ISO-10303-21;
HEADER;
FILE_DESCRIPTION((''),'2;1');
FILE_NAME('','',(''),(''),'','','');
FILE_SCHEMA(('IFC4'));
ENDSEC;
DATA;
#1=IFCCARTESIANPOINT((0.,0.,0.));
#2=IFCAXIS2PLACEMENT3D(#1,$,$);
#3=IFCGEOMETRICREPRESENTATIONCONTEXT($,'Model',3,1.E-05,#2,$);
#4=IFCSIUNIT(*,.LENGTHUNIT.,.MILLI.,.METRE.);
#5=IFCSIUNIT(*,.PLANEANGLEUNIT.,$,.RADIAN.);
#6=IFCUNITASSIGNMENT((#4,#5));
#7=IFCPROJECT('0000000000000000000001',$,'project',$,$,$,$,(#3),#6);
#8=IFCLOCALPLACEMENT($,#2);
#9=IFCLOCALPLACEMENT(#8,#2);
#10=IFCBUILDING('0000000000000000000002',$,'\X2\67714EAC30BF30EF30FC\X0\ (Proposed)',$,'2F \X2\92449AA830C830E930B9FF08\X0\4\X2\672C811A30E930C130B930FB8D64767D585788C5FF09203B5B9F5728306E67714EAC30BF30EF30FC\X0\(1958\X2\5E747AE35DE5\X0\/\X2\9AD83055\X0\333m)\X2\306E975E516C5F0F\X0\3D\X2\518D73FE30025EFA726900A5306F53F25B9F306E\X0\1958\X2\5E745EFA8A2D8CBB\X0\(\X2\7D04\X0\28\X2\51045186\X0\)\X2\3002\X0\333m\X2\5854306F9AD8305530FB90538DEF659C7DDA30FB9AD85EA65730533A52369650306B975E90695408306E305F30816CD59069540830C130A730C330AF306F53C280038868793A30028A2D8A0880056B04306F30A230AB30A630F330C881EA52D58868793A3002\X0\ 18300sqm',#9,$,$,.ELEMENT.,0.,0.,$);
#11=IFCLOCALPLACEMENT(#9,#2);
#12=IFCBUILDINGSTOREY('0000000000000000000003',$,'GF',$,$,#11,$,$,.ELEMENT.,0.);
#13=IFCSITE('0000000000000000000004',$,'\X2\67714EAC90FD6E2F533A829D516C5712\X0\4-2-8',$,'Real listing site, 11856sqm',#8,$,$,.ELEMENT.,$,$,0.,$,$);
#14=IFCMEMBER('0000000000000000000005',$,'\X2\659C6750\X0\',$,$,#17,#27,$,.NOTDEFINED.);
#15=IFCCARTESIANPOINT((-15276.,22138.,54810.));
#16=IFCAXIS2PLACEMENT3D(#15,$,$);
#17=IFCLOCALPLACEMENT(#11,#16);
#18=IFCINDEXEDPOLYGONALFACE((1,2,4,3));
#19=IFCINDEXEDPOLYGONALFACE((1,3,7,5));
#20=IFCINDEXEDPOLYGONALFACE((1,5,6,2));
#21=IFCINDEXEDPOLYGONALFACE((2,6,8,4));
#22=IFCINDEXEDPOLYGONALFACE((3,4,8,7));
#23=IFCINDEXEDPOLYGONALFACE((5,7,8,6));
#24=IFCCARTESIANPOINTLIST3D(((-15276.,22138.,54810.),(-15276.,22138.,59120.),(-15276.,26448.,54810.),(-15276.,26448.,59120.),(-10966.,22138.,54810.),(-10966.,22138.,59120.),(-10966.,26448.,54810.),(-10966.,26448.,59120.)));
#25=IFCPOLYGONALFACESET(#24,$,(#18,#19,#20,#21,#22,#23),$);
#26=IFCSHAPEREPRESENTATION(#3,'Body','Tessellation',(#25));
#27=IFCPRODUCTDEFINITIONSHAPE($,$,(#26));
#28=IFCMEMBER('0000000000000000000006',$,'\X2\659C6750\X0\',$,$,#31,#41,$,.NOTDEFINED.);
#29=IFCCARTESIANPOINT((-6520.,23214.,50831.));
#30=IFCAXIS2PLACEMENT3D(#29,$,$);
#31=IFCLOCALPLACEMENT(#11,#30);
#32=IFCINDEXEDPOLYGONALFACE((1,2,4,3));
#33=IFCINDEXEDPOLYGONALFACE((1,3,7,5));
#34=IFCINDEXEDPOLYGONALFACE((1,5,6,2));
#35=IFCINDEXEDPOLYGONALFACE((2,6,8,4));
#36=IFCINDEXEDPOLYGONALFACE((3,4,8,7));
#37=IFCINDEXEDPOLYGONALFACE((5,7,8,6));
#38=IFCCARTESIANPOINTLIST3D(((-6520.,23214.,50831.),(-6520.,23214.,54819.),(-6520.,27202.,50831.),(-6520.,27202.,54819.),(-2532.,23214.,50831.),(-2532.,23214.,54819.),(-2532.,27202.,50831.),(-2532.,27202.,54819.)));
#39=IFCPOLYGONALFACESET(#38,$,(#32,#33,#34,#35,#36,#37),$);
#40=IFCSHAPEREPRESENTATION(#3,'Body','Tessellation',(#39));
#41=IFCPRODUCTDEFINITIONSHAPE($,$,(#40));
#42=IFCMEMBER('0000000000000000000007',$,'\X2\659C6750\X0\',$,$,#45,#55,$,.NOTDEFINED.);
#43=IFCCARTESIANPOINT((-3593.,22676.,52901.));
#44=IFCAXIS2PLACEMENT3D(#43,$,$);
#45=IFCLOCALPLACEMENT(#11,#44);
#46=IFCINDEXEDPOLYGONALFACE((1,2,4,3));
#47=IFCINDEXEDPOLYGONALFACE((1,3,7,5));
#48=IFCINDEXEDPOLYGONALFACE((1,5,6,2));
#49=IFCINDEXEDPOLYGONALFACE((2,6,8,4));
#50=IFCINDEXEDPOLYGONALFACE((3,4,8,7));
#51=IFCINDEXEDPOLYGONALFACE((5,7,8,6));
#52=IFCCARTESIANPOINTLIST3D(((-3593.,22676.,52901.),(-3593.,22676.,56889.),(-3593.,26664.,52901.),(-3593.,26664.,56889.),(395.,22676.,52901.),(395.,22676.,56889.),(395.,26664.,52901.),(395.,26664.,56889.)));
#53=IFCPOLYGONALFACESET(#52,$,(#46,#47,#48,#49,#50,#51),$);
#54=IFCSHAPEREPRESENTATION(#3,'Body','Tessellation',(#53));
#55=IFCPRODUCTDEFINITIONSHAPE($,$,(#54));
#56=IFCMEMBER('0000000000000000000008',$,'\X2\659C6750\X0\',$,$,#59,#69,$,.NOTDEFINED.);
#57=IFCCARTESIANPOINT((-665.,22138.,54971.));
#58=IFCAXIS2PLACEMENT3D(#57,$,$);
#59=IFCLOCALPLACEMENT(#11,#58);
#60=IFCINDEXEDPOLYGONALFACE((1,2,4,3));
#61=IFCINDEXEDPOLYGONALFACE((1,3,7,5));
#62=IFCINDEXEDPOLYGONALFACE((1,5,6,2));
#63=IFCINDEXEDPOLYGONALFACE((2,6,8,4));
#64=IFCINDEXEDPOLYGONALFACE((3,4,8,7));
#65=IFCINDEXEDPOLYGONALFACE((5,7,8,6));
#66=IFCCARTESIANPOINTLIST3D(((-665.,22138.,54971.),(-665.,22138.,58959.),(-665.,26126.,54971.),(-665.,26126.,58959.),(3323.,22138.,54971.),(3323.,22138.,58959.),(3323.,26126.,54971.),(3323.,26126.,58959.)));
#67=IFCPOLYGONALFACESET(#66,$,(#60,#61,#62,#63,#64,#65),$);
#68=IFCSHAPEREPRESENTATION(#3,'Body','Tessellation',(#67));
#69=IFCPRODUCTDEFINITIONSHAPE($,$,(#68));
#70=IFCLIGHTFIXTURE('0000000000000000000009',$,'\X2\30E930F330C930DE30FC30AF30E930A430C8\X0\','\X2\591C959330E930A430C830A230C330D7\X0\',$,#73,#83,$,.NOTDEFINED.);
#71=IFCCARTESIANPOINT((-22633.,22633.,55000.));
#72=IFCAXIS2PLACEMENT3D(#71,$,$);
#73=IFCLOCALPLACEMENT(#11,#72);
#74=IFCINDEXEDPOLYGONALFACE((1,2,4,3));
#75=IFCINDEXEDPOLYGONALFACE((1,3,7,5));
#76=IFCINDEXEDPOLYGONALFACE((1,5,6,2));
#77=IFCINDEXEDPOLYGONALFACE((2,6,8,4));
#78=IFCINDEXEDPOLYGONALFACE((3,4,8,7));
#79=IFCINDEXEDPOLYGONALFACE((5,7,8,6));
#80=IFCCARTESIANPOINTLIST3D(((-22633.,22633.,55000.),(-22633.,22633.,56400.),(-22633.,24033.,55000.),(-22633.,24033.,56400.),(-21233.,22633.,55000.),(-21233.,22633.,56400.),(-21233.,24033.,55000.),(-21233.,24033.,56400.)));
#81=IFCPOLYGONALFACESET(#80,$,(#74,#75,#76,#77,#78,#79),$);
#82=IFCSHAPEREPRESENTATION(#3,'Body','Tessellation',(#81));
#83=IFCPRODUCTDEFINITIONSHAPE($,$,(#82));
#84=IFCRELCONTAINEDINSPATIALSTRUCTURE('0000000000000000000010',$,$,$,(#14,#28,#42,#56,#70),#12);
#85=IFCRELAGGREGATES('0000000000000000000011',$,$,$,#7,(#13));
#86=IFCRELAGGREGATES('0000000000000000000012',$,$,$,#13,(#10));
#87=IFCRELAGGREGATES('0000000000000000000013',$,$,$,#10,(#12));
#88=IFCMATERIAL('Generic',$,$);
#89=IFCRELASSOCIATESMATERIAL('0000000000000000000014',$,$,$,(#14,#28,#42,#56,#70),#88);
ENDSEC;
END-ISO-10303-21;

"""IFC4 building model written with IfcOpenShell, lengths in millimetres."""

from ifc_helpers import new_model, si_unit, frame, frame_2d, origin, place, context, project, spatial, rectangle, extrude, material, element, save


model = new_model("IFC4")

# Units and contexts
model_context = context("Model", 3, precision=1e-05, world=origin())
ifc_project = project(units=[si_unit("LENGTHUNIT", "METRE", prefix="MILLI"), si_unit("PLANEANGLEUNIT", "RADIAN")], contexts=[model_context])

# Site, building, storey
site_placement = place(None, origin())
site = spatial("IfcSite", under=ifc_project, at=site_placement, Name="東京都港区芝公園4-2-8", ObjectType="Real listing site, 11856sqm", CompositionType="ELEMENT", RefElevation=0.0)
building_placement = place(site_placement, origin())
building = spatial("IfcBuilding", under=site, at=building_placement, Name="東京タワー (Proposed)", ObjectType="2F 鉄骨トラス（4本脚ラチス・赤白塗装）※実在の東京タワー(1958年竣工/高さ333m)の非公式3D再現。建物¥は史実の1958年建設費(約28億円)。333m塔は高さ・道路斜線・高度地区制限に非適合のため法適合チェックは参考表示。設計者欄はアカウント自動表示。 18300sqm", CompositionType="ELEMENT", ElevationOfRefHeight=0.0, ElevationOfTerrain=0.0)
storey_placement = place(building_placement, origin())
storey = spatial("IfcBuildingStorey", under=building, at=storey_placement, Name="GF", CompositionType="ELEMENT", Elevation=0.0)

# Shared definitions
ifc_material = material(Name="Generic")

# Members
member_1_placement = place(storey_placement, frame((-15276.0, 22138.0, 54810.0)))
element("IfcMember", 1, at=member_1_placement, inside=storey, material=ifc_material, Name="斜材", PredefinedType="NOTDEFINED", context=model_context, shape_type="SweptSolid", body=[
    extrude(rectangle(XDim=4310.0, YDim=4310.0, at=frame_2d((2155.0, 2155.0))), frame((-15276.0, 22138.0, 54810.0)), (0.0, 0.0, 1.0), 4310.0),
])
member_2_placement = place(storey_placement, frame((-6520.0, 23214.0, 50831.0)))
element("IfcMember", 2, at=member_2_placement, inside=storey, material=ifc_material, Name="斜材", PredefinedType="NOTDEFINED", context=model_context, shape_type="SweptSolid", body=[
    extrude(rectangle(XDim=3988.0, YDim=3988.0, at=frame_2d((1994.0, 1994.0))), frame((-6520.0, 23214.0, 50831.0)), (0.0, 0.0, 1.0), 3988.0),
])
member_3_placement = place(storey_placement, frame((-3593.0, 22676.0, 52901.0)))
element("IfcMember", 3, at=member_3_placement, inside=storey, material=ifc_material, Name="斜材", PredefinedType="NOTDEFINED", context=model_context, shape_type="SweptSolid", body=[
    extrude(rectangle(XDim=3988.0, YDim=3988.0, at=frame_2d((1994.0, 1994.0))), frame((-3593.0, 22676.0, 52901.0)), (0.0, 0.0, 1.0), 3988.0),
])
member_4_placement = place(storey_placement, frame((-665.0, 22138.0, 54971.0)))
element("IfcMember", 4, at=member_4_placement, inside=storey, material=ifc_material, Name="斜材", PredefinedType="NOTDEFINED", context=model_context, shape_type="SweptSolid", body=[
    extrude(rectangle(XDim=3988.0, YDim=3988.0, at=frame_2d((1994.0, 1994.0))), frame((-665.0, 22138.0, 54971.0)), (0.0, 0.0, 1.0), 3988.0),
])

# Light fixture
light_fixture_placement = place(storey_placement, frame((-22633.0, 22633.0, 55000.0)))
element("IfcLightFixture", 5, at=light_fixture_placement, inside=storey, material=ifc_material, Name="ランドマークライト", Description="夜間ライトアップ", PredefinedType="NOTDEFINED", context=model_context, shape_type="SweptSolid", body=[
    extrude(rectangle(XDim=1400.0, YDim=1400.0, at=frame_2d((700.0, 700.0))), frame((-22633.0, 22633.0, 55000.0)), (0.0, 0.0, 1.0), 1400.0),
])

save(model, "model.ifc")
